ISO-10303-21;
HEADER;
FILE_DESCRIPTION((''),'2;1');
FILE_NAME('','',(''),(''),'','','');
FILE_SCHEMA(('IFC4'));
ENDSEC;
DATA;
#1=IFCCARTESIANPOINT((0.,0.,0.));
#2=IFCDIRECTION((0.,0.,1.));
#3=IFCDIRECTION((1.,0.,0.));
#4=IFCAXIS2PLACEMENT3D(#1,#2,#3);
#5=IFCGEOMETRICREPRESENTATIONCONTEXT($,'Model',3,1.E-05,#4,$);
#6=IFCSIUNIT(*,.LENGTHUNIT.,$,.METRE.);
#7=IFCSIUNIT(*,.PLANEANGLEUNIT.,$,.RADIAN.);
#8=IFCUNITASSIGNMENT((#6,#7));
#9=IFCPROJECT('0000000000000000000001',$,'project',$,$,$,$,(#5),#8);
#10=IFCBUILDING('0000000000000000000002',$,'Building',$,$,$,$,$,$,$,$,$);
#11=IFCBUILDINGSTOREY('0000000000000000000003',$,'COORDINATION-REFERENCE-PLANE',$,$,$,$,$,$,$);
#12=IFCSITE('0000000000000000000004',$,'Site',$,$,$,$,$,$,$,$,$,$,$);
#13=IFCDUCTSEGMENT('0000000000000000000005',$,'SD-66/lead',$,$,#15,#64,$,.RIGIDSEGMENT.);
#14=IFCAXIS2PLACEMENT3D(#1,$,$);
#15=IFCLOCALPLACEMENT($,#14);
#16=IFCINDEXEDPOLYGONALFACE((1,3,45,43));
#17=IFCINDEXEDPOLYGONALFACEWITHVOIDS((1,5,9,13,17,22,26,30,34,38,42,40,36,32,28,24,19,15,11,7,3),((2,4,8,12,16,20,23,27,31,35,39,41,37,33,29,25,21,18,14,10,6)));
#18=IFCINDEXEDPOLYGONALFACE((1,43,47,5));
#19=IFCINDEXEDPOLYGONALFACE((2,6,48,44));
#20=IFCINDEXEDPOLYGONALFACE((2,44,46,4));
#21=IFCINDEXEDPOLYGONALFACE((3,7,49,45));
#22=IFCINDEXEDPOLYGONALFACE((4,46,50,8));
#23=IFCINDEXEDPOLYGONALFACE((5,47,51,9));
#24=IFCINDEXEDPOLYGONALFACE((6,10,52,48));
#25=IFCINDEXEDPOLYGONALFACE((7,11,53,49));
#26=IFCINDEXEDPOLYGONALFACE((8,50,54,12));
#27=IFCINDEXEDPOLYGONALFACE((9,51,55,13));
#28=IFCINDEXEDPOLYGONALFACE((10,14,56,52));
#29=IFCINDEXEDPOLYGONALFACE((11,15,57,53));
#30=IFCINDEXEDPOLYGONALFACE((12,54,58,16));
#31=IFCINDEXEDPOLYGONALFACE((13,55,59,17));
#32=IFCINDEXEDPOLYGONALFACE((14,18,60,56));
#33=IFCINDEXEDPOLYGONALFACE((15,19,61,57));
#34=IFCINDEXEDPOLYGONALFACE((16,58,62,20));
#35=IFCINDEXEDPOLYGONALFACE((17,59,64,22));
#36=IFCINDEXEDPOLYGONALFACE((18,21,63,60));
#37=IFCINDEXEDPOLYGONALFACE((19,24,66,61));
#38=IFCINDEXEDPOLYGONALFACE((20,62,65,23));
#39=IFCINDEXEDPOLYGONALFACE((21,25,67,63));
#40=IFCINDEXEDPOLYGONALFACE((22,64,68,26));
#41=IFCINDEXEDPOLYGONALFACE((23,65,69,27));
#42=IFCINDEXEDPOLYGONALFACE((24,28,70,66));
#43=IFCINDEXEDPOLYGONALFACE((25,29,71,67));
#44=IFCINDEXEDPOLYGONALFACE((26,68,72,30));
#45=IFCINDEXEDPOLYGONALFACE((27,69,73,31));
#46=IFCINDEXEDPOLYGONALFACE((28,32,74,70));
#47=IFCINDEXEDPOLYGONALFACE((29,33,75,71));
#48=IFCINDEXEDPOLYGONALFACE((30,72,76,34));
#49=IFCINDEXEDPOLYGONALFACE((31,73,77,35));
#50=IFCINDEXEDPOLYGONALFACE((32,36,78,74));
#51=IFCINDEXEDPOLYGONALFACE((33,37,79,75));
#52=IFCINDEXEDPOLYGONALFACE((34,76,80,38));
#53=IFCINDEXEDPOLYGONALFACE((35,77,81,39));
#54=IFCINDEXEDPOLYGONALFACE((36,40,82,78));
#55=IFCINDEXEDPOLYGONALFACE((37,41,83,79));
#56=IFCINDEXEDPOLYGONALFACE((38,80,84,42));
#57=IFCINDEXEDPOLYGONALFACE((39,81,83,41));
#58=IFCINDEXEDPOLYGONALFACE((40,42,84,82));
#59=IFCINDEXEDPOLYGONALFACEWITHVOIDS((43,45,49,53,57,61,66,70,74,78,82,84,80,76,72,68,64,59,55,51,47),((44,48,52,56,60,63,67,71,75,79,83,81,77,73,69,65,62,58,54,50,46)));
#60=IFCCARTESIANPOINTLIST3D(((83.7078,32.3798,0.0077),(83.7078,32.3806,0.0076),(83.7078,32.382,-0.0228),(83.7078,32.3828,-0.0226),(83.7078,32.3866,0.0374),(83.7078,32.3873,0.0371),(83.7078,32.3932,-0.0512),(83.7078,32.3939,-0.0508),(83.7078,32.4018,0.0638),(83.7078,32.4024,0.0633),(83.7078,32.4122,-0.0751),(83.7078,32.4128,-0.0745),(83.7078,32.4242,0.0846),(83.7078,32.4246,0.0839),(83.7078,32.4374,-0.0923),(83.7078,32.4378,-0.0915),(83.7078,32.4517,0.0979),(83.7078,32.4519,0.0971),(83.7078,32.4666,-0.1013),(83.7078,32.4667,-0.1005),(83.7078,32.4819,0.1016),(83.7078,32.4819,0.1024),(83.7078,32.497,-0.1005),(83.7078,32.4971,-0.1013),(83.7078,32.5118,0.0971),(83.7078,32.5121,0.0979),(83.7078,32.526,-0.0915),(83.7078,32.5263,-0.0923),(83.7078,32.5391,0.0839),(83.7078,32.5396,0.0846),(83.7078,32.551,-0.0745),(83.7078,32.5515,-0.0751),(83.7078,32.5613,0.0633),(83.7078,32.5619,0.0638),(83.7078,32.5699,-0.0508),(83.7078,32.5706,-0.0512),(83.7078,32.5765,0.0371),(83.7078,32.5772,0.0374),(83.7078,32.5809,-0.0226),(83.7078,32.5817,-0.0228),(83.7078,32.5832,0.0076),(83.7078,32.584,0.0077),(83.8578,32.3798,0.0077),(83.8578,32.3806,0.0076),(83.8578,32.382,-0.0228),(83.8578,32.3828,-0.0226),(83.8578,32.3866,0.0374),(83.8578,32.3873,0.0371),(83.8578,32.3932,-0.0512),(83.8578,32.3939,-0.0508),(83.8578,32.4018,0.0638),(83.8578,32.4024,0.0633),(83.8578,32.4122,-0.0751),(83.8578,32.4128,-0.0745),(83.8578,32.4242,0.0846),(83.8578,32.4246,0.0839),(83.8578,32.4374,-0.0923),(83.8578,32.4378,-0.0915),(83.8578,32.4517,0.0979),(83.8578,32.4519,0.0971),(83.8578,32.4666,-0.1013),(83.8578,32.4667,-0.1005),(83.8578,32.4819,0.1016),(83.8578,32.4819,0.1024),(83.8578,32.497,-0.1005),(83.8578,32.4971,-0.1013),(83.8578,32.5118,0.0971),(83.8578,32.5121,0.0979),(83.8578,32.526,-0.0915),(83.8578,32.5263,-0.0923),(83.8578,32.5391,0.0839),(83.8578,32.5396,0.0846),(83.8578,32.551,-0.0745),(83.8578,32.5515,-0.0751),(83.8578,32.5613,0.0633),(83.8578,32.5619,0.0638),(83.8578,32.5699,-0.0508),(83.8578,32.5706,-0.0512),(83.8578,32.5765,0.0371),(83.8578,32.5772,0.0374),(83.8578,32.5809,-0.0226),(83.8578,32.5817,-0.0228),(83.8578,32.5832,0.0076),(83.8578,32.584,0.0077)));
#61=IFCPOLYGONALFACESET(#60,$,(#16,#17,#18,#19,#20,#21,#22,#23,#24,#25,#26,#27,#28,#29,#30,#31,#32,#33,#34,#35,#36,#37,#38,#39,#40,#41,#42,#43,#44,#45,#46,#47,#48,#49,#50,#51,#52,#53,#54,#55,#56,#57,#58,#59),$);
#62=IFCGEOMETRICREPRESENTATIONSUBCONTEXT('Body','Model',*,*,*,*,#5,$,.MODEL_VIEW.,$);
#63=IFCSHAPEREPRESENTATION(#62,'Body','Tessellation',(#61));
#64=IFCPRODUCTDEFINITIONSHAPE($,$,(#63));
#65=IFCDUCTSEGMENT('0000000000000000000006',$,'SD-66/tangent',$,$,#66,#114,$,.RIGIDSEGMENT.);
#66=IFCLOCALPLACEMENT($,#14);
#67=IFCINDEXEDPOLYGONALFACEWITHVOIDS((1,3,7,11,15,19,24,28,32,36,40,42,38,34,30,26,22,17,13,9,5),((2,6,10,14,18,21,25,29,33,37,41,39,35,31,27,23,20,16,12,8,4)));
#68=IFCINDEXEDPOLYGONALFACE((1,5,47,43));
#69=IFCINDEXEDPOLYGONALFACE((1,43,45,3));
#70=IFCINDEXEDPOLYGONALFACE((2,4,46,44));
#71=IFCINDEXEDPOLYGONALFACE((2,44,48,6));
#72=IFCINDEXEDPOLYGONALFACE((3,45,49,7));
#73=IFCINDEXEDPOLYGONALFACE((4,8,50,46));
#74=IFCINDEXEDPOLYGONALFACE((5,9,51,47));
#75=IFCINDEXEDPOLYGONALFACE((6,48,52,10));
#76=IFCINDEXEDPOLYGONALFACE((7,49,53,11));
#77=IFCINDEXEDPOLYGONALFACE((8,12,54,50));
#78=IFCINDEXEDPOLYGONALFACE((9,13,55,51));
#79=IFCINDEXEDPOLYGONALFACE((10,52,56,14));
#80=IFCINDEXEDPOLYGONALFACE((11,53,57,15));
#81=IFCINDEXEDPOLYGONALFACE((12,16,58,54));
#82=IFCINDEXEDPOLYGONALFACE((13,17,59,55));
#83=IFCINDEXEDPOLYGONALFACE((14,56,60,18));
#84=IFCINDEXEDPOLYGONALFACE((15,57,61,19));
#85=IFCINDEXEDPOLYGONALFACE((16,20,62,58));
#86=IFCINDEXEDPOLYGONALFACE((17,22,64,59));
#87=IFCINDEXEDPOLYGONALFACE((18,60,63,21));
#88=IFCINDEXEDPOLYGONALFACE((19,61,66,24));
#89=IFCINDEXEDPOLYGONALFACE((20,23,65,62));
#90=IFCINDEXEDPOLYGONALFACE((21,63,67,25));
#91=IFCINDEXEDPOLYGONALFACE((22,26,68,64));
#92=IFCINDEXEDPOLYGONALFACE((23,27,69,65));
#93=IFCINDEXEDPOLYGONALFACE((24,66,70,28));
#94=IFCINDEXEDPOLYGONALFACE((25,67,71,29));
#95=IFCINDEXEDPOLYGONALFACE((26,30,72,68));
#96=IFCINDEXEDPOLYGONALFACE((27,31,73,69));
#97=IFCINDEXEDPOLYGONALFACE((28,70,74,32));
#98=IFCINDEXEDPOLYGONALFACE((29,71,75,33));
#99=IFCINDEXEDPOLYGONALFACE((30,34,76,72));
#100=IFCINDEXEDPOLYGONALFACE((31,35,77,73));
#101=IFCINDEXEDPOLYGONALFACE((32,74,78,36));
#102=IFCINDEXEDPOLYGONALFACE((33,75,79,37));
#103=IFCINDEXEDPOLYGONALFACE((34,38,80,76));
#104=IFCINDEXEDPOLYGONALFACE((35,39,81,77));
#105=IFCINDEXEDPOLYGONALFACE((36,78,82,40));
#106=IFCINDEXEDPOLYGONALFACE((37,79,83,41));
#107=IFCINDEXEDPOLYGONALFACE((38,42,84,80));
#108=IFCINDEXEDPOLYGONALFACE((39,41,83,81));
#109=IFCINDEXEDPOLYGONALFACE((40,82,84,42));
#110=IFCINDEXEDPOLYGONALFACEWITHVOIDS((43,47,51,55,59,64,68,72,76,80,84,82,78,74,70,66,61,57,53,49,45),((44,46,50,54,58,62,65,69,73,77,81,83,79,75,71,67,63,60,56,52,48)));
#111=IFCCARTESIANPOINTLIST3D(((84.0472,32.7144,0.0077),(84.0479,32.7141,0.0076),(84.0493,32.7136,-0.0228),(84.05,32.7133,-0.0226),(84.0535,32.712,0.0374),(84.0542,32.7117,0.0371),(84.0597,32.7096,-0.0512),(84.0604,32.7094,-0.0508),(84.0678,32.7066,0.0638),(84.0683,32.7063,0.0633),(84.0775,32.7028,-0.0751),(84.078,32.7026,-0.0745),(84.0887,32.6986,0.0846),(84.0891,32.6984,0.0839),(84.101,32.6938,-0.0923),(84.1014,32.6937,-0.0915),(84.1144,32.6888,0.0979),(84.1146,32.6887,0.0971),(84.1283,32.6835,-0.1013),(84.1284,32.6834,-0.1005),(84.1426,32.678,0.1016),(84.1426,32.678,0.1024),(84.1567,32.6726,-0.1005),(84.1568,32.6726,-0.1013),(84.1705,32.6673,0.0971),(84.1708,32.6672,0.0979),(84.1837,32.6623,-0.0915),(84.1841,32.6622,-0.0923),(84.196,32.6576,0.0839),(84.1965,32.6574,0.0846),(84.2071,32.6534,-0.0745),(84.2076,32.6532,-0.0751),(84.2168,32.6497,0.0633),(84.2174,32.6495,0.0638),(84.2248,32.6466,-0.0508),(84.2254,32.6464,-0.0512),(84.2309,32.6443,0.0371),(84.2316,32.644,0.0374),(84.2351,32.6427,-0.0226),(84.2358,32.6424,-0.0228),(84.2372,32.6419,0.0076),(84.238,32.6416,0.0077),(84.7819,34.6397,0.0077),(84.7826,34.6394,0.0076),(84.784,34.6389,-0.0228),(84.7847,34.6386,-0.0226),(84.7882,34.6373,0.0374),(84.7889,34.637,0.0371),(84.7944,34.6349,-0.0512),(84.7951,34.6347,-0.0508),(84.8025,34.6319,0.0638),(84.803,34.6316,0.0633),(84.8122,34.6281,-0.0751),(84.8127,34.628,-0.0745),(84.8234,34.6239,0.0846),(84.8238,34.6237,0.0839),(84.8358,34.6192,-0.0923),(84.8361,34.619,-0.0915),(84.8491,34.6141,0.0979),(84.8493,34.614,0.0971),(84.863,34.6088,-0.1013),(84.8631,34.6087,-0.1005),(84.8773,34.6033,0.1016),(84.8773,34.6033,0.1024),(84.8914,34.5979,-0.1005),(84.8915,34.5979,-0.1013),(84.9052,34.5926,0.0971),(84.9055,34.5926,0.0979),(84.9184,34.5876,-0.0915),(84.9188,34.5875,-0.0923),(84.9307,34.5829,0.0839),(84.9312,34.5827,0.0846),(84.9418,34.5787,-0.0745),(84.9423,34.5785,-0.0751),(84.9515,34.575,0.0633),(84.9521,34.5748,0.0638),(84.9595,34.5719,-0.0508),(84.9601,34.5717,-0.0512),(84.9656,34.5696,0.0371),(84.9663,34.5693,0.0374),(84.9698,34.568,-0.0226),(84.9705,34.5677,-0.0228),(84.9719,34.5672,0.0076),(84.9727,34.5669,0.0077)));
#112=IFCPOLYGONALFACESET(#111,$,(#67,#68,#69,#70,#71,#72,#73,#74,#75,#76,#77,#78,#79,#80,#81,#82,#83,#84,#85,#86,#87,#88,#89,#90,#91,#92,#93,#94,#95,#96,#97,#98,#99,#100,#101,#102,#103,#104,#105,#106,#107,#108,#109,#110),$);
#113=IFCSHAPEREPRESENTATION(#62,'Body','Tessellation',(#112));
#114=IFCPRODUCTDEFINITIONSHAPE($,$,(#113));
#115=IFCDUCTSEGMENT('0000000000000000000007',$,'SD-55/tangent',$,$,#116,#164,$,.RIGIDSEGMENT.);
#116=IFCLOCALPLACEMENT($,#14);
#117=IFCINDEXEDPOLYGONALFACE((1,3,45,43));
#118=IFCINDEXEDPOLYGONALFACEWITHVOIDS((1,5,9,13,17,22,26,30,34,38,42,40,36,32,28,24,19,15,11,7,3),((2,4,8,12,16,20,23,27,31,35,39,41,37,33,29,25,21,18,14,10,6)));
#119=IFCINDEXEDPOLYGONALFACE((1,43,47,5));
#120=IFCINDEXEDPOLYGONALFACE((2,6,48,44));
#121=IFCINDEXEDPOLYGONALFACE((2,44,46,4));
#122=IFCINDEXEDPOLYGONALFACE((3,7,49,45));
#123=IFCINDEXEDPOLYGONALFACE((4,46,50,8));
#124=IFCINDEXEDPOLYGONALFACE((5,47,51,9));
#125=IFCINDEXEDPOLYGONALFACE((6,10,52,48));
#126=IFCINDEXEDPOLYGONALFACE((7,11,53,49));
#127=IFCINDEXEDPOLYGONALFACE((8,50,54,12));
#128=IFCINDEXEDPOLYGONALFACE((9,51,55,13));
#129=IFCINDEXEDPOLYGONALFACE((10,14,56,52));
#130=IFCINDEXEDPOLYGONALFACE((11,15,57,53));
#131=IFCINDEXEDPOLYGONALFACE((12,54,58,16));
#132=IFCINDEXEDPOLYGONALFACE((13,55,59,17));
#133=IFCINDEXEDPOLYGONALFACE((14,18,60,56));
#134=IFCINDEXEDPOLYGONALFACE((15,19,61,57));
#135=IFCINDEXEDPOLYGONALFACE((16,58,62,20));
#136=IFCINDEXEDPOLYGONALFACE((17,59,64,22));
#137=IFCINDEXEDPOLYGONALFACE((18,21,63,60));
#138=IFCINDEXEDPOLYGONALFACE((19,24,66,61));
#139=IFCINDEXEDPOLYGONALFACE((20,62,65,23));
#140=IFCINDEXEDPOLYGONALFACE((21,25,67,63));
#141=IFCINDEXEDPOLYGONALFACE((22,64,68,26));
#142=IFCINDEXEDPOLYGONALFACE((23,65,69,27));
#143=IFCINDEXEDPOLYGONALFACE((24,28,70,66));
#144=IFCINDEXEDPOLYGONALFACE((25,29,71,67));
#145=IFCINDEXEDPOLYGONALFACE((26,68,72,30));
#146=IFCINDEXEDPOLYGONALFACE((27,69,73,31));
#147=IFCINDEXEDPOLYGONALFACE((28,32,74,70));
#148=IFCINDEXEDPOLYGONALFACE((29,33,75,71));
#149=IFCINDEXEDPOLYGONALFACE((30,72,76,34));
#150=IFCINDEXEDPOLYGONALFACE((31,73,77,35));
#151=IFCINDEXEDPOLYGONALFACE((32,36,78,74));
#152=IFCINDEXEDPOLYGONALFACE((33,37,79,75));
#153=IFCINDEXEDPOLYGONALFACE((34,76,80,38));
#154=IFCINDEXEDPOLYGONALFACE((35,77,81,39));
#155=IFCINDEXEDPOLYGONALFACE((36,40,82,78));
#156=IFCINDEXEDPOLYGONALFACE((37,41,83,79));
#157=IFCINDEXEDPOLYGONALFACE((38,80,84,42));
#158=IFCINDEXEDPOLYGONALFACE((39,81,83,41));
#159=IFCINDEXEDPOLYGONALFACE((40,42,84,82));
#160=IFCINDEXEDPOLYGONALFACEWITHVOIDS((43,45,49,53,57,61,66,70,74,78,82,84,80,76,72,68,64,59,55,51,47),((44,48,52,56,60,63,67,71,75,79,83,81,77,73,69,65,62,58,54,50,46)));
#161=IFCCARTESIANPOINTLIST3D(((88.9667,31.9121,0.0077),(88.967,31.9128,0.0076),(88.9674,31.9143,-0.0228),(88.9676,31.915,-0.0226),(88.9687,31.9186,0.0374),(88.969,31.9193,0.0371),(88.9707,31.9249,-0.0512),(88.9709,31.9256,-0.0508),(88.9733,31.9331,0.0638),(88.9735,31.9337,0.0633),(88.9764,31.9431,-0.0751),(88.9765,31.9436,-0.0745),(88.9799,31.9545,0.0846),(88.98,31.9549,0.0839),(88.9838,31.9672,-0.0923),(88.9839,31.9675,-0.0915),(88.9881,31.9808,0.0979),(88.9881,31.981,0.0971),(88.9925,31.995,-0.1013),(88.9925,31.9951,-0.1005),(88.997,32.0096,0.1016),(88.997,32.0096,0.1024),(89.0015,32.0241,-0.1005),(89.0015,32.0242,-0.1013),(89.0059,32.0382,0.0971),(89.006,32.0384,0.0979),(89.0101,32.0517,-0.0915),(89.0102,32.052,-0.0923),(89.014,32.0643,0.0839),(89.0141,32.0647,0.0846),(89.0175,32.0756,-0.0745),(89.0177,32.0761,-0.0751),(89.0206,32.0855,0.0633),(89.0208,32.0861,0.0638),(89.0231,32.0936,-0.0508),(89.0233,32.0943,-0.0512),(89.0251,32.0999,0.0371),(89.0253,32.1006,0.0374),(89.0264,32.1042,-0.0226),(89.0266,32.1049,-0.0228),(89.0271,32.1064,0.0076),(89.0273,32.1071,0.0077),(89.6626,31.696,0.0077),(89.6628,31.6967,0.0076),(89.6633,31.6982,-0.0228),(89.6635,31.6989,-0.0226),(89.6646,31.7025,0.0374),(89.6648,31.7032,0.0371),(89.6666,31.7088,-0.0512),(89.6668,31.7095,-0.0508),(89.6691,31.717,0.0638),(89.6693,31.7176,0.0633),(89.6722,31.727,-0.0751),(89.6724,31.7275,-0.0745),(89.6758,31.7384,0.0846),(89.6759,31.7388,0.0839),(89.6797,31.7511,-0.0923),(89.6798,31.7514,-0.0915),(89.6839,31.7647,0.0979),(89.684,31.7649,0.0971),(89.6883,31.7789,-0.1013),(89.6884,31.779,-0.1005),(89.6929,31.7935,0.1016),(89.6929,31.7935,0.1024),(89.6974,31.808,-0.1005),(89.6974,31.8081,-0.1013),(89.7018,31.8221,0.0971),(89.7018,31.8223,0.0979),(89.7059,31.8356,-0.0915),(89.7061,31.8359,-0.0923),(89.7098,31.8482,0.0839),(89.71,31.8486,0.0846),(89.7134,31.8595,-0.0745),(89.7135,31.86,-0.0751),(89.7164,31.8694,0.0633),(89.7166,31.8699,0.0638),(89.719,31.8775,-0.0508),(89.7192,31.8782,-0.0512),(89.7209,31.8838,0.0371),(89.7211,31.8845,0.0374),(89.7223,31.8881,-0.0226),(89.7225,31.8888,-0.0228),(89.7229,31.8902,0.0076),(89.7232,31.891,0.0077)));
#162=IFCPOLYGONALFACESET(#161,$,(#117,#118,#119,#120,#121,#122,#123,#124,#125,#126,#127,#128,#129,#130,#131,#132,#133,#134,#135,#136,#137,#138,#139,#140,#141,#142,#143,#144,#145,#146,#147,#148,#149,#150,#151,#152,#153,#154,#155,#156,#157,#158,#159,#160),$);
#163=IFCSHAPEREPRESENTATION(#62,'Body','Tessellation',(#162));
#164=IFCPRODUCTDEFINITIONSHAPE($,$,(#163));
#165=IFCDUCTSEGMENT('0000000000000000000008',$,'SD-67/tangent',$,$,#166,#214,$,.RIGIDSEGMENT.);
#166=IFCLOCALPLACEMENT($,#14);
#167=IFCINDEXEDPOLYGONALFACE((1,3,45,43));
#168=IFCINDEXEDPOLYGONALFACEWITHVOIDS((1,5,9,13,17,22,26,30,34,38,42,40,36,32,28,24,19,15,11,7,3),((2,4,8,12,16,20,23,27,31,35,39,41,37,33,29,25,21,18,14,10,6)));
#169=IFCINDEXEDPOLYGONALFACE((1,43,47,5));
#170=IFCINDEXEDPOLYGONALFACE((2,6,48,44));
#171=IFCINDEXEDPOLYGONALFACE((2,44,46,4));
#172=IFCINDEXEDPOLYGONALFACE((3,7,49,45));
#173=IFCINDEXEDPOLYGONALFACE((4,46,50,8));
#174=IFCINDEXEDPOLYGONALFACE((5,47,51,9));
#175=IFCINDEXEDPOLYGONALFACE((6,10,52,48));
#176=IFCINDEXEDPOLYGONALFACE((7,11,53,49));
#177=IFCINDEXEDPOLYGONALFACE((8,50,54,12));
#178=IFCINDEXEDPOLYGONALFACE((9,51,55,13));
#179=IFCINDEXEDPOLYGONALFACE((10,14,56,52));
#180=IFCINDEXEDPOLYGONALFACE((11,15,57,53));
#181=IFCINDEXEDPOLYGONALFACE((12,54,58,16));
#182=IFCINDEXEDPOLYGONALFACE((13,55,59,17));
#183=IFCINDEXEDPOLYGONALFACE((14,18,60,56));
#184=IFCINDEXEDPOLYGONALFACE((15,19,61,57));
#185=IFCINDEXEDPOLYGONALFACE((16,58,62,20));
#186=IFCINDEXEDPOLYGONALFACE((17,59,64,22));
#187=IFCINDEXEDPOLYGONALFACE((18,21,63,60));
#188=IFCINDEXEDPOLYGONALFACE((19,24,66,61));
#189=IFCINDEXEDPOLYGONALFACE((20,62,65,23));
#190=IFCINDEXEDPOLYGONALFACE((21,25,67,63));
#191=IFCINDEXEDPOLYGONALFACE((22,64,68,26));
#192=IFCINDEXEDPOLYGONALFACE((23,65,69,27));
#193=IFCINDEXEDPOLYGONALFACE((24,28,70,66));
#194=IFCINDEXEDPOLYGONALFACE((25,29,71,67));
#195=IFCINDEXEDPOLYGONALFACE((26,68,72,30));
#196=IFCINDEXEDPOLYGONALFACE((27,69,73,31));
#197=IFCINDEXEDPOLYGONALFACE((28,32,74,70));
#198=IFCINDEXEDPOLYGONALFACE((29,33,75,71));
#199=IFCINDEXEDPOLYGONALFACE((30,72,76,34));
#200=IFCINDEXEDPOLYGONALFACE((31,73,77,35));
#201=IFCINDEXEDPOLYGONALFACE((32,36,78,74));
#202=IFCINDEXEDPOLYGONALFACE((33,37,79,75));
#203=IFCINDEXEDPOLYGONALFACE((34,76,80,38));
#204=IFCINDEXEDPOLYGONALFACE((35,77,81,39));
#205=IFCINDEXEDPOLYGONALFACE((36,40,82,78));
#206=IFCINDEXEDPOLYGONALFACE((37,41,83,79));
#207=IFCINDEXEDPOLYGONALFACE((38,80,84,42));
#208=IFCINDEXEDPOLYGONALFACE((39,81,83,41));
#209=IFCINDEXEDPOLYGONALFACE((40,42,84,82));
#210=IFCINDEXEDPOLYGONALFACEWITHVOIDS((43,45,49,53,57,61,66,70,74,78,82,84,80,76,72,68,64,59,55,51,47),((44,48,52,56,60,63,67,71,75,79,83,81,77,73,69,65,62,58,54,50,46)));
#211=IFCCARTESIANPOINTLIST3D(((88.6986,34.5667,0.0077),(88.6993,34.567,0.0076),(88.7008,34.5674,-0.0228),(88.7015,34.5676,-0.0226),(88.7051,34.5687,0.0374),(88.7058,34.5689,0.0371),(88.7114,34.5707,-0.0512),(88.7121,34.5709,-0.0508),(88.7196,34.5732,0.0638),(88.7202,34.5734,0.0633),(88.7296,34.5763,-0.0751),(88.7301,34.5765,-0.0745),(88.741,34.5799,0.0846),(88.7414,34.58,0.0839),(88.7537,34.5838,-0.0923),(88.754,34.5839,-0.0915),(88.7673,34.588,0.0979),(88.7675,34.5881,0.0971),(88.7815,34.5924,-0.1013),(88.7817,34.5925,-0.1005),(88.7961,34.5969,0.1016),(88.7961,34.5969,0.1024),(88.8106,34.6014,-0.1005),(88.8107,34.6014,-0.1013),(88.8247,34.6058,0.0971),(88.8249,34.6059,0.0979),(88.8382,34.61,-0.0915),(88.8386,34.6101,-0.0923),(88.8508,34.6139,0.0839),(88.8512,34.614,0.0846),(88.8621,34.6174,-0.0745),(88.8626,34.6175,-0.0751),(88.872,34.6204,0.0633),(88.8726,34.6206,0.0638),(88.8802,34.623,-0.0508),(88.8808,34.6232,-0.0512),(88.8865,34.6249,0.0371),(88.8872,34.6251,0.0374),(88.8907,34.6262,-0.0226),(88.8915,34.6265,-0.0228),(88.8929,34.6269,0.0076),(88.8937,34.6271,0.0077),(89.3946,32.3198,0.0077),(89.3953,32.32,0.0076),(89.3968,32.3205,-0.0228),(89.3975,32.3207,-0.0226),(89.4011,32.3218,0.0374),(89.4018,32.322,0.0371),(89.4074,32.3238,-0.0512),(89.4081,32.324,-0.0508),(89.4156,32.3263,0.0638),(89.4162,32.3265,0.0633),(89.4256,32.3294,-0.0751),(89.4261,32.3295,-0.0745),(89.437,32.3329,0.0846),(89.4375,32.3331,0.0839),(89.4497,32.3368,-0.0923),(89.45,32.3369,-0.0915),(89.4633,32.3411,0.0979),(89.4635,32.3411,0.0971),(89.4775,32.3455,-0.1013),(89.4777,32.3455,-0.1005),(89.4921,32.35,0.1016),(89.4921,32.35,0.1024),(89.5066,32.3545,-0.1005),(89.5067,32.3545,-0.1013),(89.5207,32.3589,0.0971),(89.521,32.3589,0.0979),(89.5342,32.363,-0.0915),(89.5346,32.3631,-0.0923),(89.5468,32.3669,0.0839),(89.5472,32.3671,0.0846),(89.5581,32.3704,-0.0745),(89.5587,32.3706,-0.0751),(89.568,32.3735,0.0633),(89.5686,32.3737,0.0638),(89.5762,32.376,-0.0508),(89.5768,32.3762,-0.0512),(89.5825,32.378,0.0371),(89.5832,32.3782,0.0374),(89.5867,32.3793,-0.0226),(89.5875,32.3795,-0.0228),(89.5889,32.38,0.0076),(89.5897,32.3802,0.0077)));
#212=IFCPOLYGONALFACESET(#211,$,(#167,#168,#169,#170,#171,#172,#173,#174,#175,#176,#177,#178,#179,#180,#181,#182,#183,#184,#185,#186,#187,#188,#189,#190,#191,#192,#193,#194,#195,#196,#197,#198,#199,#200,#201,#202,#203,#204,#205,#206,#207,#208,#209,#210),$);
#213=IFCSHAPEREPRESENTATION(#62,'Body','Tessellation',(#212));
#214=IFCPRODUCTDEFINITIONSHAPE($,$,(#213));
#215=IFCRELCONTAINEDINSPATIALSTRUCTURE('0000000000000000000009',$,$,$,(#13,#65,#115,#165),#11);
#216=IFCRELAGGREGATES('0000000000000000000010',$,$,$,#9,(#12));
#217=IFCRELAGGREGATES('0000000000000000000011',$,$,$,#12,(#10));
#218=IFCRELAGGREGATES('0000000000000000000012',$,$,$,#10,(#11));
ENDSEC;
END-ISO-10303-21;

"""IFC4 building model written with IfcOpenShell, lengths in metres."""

from ifc_helpers import new_model, si_unit, frame, origin_with_axes, place, context, subcontext, project, spatial, hollow_circle, extrude, element, save


model = new_model("IFC4")

# Units and contexts
model_context = context("Model", 3, precision=1e-05, world=origin_with_axes())
body_context_1 = subcontext(model_context, "Body", "Model", "MODEL_VIEW")
ifc_project = project(units=[si_unit("LENGTHUNIT", "METRE"), si_unit("PLANEANGLEUNIT", "RADIAN")], contexts=[model_context])

# Site, building, storey
site = spatial("IfcSite", under=ifc_project, Name="Site")
building = spatial("IfcBuilding", under=site, Name="Building")
storey = spatial("IfcBuildingStorey", under=building, Name="COORDINATION-REFERENCE-PLANE")

# Duct segment
duct_segment_1_placement = place(None, frame((83.7078, 32.4819, 0.0), z_axis=(1.0, 0.0, 0.0), x_axis=(0.0, 0.0, 1.0)))
element("IfcDuctSegment", 1, at=duct_segment_1_placement, inside=storey, Name="SD-66/lead", PredefinedType="RIGIDSEGMENT", context=body_context_1, shape_type="SweptSolid", body=[
    extrude(hollow_circle(Radius=0.1024, WallThickness=0.0008), origin_with_axes(), (0.0, 0.0, 1.0), 0.15),
])

# Duct segment
duct_segment_2_placement = place(None, frame((84.1426, 32.678, 0.0), z_axis=(0.356527, 0.934285, 0.0), x_axis=(0.0, 0.0, 1.0)))
element("IfcDuctSegment", 2, at=duct_segment_2_placement, inside=storey, Name="SD-66/tangent", PredefinedType="RIGIDSEGMENT", context=body_context_1, shape_type="SweptSolid", body=[
    extrude(hollow_circle(Radius=0.1024, WallThickness=0.0008), origin_with_axes(), (0.0, 0.0, 1.0), 2.0607),
])

# Duct segment
duct_segment_3_placement = place(None, frame((89.6929, 31.7935, 0.0), z_axis=(-0.955005, 0.296589, 0.0), x_axis=(0.0, 0.0, 1.0)))
element("IfcDuctSegment", 3, at=duct_segment_3_placement, inside=storey, Name="SD-55/tangent", PredefinedType="RIGIDSEGMENT", context=body_context_1, shape_type="SweptSolid", body=[
    extrude(hollow_circle(Radius=0.1024, WallThickness=0.0008), origin_with_axes(), (0.0, 0.0, 1.0), 0.7286),
])

# Duct segment
duct_segment_4_placement = place(None, frame((89.4921, 32.35, 0.0), z_axis=(-0.295887, 0.955223, 0.0), x_axis=(0.0, 0.0, 1.0)))
element("IfcDuctSegment", 4, at=duct_segment_4_placement, inside=storey, Name="SD-67/tangent", PredefinedType="RIGIDSEGMENT", context=body_context_1, shape_type="SweptSolid", body=[
    extrude(hollow_circle(Radius=0.1024, WallThickness=0.0008), origin_with_axes(), (0.0, 0.0, 1.0), 2.3523),
])

save(model, "model.ifc")
